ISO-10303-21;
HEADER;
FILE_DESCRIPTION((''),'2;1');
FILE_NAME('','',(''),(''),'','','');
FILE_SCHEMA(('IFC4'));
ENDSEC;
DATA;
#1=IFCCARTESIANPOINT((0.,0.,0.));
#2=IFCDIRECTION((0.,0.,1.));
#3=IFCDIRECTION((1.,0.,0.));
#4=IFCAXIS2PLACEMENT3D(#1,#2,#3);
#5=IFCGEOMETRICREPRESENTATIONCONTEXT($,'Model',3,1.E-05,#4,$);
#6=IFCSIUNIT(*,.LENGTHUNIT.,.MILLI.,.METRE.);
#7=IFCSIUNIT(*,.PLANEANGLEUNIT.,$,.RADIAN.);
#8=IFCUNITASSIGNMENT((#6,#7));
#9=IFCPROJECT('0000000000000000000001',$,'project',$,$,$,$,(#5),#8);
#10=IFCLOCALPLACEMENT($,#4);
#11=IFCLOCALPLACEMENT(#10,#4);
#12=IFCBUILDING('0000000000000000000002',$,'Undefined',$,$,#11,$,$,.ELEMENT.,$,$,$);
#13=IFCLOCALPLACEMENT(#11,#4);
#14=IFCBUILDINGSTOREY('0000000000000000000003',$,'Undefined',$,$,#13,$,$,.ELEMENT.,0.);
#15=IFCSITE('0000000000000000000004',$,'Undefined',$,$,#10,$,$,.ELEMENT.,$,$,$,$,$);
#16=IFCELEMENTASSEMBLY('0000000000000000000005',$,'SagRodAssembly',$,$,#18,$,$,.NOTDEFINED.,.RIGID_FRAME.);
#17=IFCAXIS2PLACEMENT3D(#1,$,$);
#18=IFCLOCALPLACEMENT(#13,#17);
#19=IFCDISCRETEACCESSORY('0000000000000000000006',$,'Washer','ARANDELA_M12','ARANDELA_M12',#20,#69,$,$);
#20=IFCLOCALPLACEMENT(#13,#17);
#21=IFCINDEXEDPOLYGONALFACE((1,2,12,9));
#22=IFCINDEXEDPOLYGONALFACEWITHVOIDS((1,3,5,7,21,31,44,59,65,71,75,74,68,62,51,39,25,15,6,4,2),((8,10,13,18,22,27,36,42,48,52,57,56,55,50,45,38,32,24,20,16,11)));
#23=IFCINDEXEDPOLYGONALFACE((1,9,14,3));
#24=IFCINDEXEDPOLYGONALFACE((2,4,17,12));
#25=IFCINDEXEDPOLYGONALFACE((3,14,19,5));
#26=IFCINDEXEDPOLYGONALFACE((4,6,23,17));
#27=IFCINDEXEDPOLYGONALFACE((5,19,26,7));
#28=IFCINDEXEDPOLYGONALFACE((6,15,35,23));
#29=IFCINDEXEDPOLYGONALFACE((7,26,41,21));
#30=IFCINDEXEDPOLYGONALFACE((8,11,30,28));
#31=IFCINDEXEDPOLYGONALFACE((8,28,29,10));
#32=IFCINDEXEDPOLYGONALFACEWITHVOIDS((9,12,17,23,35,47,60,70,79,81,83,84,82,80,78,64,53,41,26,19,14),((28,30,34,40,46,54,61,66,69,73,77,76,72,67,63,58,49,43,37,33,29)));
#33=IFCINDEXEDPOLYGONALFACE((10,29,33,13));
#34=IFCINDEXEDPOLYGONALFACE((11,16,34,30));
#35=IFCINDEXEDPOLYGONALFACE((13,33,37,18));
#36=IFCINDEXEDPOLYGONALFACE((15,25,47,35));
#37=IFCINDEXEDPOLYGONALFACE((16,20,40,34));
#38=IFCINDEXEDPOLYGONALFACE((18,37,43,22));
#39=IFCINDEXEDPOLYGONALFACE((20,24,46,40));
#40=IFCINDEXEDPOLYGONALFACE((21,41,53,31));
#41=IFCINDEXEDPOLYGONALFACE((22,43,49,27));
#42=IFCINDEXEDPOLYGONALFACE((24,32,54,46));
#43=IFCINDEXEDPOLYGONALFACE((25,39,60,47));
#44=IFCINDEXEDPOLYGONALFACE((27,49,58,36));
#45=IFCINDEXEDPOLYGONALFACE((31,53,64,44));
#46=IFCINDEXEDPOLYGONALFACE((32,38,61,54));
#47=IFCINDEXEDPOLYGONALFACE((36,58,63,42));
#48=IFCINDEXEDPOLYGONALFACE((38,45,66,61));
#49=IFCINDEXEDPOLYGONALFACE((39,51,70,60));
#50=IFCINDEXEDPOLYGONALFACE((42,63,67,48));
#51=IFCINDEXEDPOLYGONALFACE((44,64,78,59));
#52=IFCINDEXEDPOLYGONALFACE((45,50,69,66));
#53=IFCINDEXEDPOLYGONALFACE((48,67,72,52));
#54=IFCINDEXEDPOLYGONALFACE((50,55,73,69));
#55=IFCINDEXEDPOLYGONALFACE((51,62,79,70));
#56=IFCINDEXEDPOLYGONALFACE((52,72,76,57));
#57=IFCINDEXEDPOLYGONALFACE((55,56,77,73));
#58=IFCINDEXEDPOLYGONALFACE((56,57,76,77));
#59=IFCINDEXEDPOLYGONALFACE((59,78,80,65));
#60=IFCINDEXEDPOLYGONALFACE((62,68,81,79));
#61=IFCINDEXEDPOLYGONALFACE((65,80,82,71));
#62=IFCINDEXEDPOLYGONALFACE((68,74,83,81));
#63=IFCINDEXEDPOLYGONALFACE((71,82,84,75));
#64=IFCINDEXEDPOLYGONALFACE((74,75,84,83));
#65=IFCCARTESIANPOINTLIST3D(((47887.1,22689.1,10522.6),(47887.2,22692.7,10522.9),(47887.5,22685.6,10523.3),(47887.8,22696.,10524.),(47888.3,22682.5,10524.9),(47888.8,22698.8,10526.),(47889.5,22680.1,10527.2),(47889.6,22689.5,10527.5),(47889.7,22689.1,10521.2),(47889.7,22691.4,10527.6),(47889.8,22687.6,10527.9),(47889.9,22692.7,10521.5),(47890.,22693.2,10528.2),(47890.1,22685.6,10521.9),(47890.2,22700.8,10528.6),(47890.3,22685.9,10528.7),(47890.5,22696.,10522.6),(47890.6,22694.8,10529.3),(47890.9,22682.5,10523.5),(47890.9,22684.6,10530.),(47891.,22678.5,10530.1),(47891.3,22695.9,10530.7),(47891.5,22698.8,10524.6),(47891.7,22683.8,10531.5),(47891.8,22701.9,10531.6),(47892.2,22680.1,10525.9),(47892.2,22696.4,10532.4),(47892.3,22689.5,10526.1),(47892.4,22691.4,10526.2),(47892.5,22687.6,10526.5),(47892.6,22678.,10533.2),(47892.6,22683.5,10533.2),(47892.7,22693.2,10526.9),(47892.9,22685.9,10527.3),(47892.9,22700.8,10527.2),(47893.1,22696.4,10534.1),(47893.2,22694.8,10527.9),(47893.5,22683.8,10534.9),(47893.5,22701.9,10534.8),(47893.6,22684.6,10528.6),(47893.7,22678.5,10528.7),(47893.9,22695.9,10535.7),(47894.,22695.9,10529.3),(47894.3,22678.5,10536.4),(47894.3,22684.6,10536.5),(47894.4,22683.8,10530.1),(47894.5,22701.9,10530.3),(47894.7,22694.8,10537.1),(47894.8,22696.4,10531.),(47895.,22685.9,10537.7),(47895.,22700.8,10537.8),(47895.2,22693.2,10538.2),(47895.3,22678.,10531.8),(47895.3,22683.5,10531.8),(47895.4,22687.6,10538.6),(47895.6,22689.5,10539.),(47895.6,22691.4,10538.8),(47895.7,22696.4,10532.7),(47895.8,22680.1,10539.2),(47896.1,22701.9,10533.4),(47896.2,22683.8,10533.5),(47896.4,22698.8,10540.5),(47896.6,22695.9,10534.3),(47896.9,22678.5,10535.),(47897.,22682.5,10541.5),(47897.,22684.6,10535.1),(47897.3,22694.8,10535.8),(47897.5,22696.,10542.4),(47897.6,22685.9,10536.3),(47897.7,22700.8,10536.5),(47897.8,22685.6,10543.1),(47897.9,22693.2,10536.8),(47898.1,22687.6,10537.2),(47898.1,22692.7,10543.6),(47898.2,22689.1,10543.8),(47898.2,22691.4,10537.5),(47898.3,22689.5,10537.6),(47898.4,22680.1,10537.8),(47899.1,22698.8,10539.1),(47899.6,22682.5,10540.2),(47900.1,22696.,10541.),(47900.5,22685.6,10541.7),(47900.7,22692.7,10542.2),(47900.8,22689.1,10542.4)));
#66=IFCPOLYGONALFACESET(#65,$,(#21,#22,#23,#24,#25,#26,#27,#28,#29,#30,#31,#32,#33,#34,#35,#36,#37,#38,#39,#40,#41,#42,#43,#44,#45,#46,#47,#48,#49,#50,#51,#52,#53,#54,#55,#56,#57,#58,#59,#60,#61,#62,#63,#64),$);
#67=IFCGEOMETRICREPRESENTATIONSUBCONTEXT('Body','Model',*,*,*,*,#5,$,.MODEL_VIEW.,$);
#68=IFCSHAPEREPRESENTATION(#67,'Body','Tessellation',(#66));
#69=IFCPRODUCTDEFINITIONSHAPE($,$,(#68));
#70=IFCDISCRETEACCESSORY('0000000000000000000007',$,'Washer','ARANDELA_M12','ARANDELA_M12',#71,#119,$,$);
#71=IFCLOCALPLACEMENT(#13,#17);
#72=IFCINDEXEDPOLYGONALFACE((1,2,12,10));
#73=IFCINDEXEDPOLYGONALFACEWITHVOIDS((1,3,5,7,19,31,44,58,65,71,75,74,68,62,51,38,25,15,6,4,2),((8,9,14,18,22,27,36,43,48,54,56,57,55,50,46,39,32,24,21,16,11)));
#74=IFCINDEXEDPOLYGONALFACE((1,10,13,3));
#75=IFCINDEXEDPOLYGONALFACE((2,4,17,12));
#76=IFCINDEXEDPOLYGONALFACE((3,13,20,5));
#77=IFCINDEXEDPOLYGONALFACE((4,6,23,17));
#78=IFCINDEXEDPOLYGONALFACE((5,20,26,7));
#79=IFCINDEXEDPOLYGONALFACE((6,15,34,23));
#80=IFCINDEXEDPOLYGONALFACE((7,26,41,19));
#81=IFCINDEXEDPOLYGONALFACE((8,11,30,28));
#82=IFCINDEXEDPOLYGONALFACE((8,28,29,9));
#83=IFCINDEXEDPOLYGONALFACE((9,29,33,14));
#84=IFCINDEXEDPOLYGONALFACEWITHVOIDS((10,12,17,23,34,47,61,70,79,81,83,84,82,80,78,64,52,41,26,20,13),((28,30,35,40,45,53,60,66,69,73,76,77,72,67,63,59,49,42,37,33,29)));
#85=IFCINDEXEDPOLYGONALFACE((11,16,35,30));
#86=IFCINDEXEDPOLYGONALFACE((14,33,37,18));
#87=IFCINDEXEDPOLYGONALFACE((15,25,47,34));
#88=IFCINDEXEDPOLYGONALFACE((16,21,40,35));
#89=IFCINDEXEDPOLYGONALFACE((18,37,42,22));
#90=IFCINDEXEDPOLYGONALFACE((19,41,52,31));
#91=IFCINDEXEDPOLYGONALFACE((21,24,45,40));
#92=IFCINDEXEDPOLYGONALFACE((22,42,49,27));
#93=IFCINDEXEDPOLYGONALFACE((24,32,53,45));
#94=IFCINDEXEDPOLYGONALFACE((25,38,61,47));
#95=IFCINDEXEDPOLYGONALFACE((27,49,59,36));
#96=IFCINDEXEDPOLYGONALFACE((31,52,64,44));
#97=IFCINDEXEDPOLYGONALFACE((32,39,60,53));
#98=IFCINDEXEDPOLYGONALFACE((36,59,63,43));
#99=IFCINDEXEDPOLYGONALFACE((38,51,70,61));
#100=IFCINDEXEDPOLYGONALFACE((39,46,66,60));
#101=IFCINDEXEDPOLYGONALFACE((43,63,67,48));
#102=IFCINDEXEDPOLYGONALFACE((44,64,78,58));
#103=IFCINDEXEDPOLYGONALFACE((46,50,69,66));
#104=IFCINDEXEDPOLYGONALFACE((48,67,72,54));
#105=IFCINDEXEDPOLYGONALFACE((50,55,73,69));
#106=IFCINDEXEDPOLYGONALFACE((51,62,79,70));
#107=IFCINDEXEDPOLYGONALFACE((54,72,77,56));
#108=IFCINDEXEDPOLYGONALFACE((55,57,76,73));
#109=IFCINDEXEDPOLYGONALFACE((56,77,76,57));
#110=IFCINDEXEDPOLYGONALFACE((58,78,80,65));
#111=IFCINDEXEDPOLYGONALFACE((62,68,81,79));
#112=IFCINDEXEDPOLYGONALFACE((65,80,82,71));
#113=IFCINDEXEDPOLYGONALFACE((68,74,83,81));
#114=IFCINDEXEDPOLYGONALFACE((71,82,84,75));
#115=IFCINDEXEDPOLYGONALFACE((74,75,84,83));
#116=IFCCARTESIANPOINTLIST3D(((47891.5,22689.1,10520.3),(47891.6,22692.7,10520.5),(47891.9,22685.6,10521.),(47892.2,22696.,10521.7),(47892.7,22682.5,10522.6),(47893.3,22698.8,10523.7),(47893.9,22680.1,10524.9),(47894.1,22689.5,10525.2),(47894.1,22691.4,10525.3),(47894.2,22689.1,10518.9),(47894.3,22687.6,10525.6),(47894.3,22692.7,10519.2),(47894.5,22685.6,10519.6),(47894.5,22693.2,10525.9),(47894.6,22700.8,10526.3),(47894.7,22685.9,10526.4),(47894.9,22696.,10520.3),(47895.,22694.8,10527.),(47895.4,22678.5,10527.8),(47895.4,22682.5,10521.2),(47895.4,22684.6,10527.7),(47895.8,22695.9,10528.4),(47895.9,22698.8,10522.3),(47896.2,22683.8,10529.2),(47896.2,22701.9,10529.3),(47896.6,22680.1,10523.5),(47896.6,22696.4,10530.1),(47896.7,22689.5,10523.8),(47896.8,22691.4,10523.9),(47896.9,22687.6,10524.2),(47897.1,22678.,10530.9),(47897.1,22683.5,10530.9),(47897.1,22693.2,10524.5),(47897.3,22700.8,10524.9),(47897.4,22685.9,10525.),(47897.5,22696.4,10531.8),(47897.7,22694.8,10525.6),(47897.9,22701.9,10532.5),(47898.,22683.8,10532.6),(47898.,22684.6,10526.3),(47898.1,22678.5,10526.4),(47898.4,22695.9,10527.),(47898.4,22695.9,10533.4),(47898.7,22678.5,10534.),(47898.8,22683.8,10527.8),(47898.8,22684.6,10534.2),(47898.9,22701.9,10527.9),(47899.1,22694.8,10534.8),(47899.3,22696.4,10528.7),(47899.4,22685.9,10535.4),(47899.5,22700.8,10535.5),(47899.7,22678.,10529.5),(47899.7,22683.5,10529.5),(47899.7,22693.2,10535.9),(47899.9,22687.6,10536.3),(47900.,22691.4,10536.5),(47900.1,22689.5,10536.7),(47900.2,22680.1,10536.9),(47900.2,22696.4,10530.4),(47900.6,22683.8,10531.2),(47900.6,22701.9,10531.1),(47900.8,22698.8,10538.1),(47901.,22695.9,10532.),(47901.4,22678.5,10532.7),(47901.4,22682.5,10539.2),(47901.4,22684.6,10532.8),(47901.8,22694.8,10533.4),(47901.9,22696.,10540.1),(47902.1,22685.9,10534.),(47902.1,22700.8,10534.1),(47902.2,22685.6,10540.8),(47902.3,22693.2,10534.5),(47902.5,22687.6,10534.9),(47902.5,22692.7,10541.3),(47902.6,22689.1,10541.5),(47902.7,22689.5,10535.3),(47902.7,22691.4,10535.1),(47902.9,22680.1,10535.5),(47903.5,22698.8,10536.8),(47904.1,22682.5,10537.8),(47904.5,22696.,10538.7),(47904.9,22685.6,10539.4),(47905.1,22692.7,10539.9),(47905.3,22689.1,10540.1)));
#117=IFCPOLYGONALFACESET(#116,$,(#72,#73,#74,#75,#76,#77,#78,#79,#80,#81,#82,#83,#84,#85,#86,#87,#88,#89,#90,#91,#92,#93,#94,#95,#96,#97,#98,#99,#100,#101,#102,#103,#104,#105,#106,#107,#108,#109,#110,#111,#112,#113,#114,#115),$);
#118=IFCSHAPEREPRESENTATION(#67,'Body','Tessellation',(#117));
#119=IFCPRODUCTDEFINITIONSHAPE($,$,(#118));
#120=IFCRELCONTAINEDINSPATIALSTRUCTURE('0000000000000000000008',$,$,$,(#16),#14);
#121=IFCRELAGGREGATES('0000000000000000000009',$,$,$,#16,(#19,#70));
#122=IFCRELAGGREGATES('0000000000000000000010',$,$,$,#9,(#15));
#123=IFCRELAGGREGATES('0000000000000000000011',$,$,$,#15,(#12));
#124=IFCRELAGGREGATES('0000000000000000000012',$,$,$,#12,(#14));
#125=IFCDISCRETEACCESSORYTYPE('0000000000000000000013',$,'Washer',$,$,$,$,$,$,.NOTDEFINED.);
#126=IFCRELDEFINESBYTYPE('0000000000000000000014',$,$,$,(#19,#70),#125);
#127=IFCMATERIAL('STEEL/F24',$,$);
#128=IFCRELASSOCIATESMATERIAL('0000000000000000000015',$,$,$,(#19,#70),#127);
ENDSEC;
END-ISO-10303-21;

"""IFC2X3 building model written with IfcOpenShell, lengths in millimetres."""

from ifc_helpers import new_model, si_unit, frame, origin_with_axes, origin_2d_with_axis, place, context, subcontext, project, spatial, hollow_circle, extrude, material, type_object, element, aggregate, save


model = new_model("IFC2X3")

# Units and contexts
model_context = context("Model", 3, precision=1e-05, world=origin_with_axes())
body_context = subcontext(model_context, "Body", "Model", "MODEL_VIEW")
ifc_project = project(units=[si_unit("LENGTHUNIT", "METRE", prefix="MILLI"), si_unit("PLANEANGLEUNIT", "RADIAN")], contexts=[model_context])

# Site, building, storey
site_placement = place(None, origin_with_axes())
site = spatial("IfcSite", under=ifc_project, at=site_placement, Name="Undefined", CompositionType="ELEMENT")
building_placement = place(site_placement, origin_with_axes())
building = spatial("IfcBuilding", under=site, at=building_placement, Name="Undefined", CompositionType="ELEMENT")
storey_placement = place(building_placement, origin_with_axes())
storey = spatial("IfcBuildingStorey", under=building, at=storey_placement, Name="Undefined", CompositionType="ELEMENT", Elevation=0.0)

# Shared definitions
ifc_material_1 = material(Name="STEEL/F24")

# Element assembly
assembly_1_placement = place(storey_placement, origin_with_axes())
assembly_1 = element("IfcElementAssembly", 1, at=assembly_1_placement, inside=storey, Name="SagRodAssembly", AssemblyPlace="NOTDEFINED", PredefinedType="RIGID_FRAME")

# Discrete accessories
discrete_accessory_type_1 = type_object("IfcDiscreteAccessoryType", Name="Washer")
discrete_accessory_1_placement = place(assembly_1_placement, frame((47895.3, 22690.0, 10531.8), z_axis=(-0.463578, 0.0, -0.886056), x_axis=(-0.886056, 0.0, 0.463578)))
discrete_accessory_1 = element("IfcDiscreteAccessory", 2, at=discrete_accessory_1_placement, type_object=discrete_accessory_type_1, material=ifc_material_1, Name="Washer", Description="ARANDELA_M12", ObjectType="ARANDELA_M12", context=body_context, shape_type="SweptSolid", body=[
    extrude(hollow_circle(Radius=12.0, WallThickness=5.5, at=origin_2d_with_axis()), frame((3.0, 0.0, 0.0), z_axis=(-1.0, 0.0, 0.0), x_axis=(0.0, -1.0, 0.0)), (0.0, 0.0, 1.0), 3.0),
])
discrete_accessory_2_placement = place(assembly_1_placement, frame((47899.7, 22690.0, 10529.5), z_axis=(-0.463578, 0.0, -0.886056), x_axis=(-0.886056, 0.0, 0.463578)))
discrete_accessory_2 = element("IfcDiscreteAccessory", 3, at=discrete_accessory_2_placement, type_object=discrete_accessory_type_1, material=ifc_material_1, Name="Washer", Description="ARANDELA_M12", ObjectType="ARANDELA_M12", context=body_context, shape_type="SweptSolid", body=[
    extrude(hollow_circle(Radius=12.0, WallThickness=5.5, at=origin_2d_with_axis()), frame((3.0, 0.0, 0.0), z_axis=(-1.0, 0.0, 0.0), x_axis=(0.0, -1.0, 0.0)), (0.0, 0.0, 1.0), 3.0),
])
aggregate(assembly_1, [discrete_accessory_1, discrete_accessory_2])

save(model, "model.ifc")
